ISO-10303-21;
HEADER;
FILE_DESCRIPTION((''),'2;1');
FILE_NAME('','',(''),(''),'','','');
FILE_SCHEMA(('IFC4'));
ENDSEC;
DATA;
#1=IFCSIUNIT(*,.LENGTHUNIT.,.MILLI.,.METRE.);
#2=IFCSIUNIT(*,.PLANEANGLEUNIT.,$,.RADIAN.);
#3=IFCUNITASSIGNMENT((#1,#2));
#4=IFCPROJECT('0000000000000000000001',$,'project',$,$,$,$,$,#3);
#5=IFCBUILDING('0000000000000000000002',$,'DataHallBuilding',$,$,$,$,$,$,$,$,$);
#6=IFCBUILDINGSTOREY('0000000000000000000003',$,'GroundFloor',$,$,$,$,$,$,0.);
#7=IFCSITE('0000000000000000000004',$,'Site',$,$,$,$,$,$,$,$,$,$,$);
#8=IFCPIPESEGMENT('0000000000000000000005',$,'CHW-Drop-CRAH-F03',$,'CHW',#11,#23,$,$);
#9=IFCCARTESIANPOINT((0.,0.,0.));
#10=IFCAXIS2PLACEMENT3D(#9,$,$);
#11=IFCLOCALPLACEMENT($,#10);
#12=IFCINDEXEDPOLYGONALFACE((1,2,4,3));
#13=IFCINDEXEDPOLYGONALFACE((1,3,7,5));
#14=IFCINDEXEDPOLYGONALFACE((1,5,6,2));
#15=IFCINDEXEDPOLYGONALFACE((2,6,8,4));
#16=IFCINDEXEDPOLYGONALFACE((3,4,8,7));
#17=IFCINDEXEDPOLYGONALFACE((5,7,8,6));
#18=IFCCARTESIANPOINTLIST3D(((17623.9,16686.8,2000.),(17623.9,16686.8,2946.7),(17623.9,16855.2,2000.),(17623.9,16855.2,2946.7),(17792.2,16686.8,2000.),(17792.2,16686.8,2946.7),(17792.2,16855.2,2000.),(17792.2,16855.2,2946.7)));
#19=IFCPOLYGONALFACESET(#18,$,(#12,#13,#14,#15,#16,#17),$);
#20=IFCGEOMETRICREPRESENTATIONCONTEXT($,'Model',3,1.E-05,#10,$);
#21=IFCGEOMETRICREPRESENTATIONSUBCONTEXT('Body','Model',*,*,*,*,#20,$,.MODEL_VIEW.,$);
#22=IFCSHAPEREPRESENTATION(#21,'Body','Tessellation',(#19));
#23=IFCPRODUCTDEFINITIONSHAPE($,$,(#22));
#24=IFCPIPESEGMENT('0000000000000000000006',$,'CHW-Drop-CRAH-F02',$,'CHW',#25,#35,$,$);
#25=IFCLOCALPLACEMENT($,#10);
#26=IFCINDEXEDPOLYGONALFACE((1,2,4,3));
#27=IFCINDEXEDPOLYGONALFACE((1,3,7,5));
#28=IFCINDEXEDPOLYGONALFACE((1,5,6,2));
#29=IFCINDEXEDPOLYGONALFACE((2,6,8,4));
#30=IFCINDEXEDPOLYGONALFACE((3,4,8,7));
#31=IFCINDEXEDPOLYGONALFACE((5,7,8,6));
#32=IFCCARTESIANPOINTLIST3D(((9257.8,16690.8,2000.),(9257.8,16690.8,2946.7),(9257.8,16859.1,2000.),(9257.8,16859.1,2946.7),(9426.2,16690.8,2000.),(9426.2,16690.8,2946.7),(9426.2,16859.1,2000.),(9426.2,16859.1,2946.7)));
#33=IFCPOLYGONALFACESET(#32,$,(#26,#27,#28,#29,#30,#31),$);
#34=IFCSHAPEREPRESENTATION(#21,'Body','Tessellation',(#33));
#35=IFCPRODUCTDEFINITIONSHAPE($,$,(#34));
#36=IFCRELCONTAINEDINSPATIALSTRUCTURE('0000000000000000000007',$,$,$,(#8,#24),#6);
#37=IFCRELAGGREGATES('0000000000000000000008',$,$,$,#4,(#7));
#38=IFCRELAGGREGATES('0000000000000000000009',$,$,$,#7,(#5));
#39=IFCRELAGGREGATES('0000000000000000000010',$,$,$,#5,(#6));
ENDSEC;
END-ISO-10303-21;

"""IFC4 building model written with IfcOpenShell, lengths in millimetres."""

from ifc_helpers import new_model, si_unit, frame, origin, place, context, subcontext, project, spatial, rectangle, extrude, element, save


model = new_model("IFC4")

# Units and contexts
model_context = context("Model", 3, precision=1e-05, world=origin())
body_context = subcontext(model_context, "Body", "Model", "MODEL_VIEW")
ifc_project = project(units=[si_unit("LENGTHUNIT", "METRE", prefix="MILLI"), si_unit("PLANEANGLEUNIT", "RADIAN")])

# Site, building, storey
site = spatial("IfcSite", under=ifc_project, Name="Site")
building = spatial("IfcBuilding", under=site, Name="DataHallBuilding")
storey = spatial("IfcBuildingStorey", under=building, Name="GroundFloor", Elevation=0.0)

# Pipe segments
pipe_segment_1_placement = place(None, origin())
element("IfcPipeSegment", 1, at=pipe_segment_1_placement, inside=storey, Name="CHW-Drop-CRAH-F03", ObjectType="CHW", context=body_context, shape_type="SweptSolid", body=[
    extrude(rectangle(XDim=168.3, YDim=168.3), frame((17708.0, 16771.0, 2000.0), z_axis=(0.0, 0.0, 1.0), x_axis=(1.0, 0.0, 0.0)), (0.0, 0.0, 1.0), 946.7),
])
pipe_segment_2_placement = place(None, origin())
element("IfcPipeSegment", 2, at=pipe_segment_2_placement, inside=storey, Name="CHW-Drop-CRAH-F02", ObjectType="CHW", context=body_context, shape_type="SweptSolid", body=[
    extrude(rectangle(XDim=168.3, YDim=168.3), frame((9342.0, 16775.0, 2000.0), z_axis=(0.0, 0.0, 1.0), x_axis=(1.0, 0.0, 0.0)), (0.0, 0.0, 1.0), 946.7),
])

save(model, "model.ifc")
